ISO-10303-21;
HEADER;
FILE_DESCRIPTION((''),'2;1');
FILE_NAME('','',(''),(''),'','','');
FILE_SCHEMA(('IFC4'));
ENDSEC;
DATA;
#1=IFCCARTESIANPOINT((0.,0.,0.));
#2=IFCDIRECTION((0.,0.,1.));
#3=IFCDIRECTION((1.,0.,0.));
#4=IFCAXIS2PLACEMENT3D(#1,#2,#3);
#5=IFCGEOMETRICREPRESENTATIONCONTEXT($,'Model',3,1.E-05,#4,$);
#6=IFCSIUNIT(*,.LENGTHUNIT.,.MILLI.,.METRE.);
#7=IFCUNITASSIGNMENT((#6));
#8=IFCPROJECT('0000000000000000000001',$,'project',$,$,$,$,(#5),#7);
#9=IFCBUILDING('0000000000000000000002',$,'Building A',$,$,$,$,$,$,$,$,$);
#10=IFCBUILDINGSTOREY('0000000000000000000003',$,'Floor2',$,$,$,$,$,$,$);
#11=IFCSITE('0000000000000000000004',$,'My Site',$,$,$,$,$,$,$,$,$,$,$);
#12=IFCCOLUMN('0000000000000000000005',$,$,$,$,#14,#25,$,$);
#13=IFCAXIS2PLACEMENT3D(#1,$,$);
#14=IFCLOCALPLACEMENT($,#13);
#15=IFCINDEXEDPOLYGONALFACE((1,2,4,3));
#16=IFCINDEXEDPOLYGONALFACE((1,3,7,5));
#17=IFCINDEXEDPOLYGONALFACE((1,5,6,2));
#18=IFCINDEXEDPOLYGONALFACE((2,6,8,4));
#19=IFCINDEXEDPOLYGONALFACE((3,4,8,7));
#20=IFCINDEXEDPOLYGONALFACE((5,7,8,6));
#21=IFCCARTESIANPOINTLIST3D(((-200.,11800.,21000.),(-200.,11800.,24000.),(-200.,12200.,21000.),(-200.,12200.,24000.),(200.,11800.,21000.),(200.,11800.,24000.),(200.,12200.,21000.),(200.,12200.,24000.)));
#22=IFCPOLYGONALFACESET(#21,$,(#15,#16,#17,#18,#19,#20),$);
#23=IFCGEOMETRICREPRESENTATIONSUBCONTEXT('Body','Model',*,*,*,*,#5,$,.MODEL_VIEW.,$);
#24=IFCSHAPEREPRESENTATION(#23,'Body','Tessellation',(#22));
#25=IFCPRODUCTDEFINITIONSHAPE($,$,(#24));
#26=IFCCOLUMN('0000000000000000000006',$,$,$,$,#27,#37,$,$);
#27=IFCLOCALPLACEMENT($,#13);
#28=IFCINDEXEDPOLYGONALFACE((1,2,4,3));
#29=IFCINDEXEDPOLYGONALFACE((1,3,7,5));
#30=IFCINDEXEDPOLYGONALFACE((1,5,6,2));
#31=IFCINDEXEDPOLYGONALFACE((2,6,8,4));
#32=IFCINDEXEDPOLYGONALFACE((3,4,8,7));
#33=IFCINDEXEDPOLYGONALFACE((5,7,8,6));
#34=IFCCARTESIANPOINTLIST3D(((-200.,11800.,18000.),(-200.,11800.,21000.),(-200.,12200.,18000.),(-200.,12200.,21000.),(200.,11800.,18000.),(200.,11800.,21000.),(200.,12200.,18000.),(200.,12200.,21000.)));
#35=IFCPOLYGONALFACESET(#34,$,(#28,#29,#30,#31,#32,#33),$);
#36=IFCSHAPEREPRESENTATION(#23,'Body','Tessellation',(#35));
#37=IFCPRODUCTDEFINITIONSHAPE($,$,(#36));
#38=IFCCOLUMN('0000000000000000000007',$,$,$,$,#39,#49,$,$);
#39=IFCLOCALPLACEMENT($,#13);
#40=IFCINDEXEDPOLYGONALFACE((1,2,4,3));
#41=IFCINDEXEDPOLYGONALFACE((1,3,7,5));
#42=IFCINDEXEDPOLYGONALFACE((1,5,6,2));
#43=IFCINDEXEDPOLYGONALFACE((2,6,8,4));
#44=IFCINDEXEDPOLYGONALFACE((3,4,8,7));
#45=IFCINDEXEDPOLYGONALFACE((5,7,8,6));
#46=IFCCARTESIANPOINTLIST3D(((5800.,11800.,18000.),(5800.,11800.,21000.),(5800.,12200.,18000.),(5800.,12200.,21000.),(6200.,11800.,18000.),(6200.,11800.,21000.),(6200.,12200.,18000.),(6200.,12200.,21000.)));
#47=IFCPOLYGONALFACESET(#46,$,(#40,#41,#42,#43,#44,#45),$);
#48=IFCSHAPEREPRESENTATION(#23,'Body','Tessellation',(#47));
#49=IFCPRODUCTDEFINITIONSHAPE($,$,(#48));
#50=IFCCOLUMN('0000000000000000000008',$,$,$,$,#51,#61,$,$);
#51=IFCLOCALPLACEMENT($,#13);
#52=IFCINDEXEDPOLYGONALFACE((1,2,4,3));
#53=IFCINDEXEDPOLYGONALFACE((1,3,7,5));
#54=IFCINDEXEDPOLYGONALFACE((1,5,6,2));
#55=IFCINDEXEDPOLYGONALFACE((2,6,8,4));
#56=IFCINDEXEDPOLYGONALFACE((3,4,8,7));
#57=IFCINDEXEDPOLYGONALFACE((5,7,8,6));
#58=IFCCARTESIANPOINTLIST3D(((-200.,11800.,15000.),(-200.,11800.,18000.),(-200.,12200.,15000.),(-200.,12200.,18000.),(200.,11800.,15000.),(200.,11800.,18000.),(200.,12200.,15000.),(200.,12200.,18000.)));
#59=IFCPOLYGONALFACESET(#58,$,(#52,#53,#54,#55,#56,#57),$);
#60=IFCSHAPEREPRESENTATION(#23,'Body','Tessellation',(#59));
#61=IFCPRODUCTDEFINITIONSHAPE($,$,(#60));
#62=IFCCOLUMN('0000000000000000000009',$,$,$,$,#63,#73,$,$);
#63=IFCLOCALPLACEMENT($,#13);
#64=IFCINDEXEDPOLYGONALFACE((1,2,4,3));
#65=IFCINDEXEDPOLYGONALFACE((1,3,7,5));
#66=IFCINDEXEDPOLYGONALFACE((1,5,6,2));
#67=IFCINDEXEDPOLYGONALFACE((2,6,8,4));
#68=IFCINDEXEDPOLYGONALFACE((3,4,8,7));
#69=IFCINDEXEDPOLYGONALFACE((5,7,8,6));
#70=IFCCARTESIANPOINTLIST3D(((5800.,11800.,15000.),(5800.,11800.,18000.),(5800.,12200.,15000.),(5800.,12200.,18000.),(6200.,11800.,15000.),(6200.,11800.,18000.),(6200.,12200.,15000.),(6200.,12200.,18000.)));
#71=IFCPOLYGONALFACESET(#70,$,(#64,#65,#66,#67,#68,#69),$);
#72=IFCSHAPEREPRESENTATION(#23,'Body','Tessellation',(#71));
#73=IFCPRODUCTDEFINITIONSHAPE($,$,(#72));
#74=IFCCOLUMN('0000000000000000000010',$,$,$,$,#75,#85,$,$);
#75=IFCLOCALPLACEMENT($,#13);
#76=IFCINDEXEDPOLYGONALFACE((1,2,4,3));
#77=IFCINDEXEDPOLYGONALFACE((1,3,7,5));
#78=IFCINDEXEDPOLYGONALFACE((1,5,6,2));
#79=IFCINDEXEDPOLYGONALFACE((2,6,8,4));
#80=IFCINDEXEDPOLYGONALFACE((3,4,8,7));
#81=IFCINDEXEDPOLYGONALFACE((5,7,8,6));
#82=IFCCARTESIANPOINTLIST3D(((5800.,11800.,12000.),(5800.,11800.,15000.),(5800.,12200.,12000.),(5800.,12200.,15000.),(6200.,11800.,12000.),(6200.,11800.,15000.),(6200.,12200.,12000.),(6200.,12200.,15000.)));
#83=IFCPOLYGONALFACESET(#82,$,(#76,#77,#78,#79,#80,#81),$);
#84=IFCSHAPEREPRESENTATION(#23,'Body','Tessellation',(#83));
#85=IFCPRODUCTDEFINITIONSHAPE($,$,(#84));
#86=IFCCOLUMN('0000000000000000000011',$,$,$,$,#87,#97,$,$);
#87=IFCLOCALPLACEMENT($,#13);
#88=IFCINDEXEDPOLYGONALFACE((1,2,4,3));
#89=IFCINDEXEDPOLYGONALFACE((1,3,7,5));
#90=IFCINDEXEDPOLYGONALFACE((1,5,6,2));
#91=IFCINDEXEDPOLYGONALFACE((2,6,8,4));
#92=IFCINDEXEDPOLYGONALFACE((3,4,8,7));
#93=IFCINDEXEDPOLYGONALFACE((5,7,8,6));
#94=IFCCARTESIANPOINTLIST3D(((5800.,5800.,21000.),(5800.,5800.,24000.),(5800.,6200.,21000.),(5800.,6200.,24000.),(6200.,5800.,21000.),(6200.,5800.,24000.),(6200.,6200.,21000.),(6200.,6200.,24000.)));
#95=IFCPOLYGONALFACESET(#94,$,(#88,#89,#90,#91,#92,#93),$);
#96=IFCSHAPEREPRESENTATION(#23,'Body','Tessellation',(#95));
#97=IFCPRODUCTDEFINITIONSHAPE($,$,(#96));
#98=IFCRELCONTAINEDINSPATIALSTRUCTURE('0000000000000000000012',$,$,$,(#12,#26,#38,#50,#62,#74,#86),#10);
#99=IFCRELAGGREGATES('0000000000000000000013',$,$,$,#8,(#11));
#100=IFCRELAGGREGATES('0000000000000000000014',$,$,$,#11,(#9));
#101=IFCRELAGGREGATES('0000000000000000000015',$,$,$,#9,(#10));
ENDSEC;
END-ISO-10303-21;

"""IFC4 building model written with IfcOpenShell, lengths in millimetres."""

from ifc_helpers import new_model, si_unit, frame, origin_with_axes, place, context, subcontext, project, spatial, line, indexed_curve, outline, extrude, element, save


model = new_model("IFC4")

# Units and contexts
model_context = context("Model", 3, precision=1e-05, world=origin_with_axes())
body_context = subcontext(model_context, "Body", "Model", "MODEL_VIEW")
ifc_project = project(units=[si_unit("LENGTHUNIT", "METRE", prefix="MILLI")], contexts=[model_context])

# Site, building, storey
site = spatial("IfcSite", under=ifc_project, Name="My Site")
building = spatial("IfcBuilding", under=site, Name="Building A")
storey = spatial("IfcBuildingStorey", under=building, Name="Floor2")

# Columns
for number, where, z_axis, x_axis in (
    (1, (0.0, 12000.0, 21000.0), (0.0, 0.0, 1.0), (1.0, 0.0, 0.0)),
    (2, (0.0, 12000.0, 18000.0), (0.0, 0.0, 1.0), (1.0, 0.0, 0.0)),
    (3, (6000.0, 12000.0, 18000.0), (0.0, 0.0, 1.0), (1.0, 0.0, 0.0)),
    (4, (0.0, 12000.0, 15000.0), (0.0, 0.0, 1.0), (1.0, 0.0, 0.0)),
    (5, (6000.0, 12000.0, 15000.0), (0.0, 0.0, 1.0), (1.0, 0.0, 0.0)),
    (6, (6000.0, 12000.0, 12000.0), (0.0, 0.0, 1.0), (1.0, 0.0, 0.0)),
    (7, (6000.0, 6000.0, 21000.0), (0.0, 0.0, 1.0), (1.0, 0.0, 0.0)),
):
    element("IfcColumn", number, at=place(None, frame(where, z_axis=z_axis, x_axis=x_axis)), inside=storey, context=body_context, shape_type="SweptSolid", body=[
        extrude(outline(indexed_curve([(-200.0, -200.0), (200.0, -200.0), (200.0, 200.0), (-200.0, 200.0)], segments=[line(1, 2, 3, 4, 1)])), origin_with_axes(), (0.0, 0.0, 1.0), 3000.0),
    ])

save(model, "model.ifc")
